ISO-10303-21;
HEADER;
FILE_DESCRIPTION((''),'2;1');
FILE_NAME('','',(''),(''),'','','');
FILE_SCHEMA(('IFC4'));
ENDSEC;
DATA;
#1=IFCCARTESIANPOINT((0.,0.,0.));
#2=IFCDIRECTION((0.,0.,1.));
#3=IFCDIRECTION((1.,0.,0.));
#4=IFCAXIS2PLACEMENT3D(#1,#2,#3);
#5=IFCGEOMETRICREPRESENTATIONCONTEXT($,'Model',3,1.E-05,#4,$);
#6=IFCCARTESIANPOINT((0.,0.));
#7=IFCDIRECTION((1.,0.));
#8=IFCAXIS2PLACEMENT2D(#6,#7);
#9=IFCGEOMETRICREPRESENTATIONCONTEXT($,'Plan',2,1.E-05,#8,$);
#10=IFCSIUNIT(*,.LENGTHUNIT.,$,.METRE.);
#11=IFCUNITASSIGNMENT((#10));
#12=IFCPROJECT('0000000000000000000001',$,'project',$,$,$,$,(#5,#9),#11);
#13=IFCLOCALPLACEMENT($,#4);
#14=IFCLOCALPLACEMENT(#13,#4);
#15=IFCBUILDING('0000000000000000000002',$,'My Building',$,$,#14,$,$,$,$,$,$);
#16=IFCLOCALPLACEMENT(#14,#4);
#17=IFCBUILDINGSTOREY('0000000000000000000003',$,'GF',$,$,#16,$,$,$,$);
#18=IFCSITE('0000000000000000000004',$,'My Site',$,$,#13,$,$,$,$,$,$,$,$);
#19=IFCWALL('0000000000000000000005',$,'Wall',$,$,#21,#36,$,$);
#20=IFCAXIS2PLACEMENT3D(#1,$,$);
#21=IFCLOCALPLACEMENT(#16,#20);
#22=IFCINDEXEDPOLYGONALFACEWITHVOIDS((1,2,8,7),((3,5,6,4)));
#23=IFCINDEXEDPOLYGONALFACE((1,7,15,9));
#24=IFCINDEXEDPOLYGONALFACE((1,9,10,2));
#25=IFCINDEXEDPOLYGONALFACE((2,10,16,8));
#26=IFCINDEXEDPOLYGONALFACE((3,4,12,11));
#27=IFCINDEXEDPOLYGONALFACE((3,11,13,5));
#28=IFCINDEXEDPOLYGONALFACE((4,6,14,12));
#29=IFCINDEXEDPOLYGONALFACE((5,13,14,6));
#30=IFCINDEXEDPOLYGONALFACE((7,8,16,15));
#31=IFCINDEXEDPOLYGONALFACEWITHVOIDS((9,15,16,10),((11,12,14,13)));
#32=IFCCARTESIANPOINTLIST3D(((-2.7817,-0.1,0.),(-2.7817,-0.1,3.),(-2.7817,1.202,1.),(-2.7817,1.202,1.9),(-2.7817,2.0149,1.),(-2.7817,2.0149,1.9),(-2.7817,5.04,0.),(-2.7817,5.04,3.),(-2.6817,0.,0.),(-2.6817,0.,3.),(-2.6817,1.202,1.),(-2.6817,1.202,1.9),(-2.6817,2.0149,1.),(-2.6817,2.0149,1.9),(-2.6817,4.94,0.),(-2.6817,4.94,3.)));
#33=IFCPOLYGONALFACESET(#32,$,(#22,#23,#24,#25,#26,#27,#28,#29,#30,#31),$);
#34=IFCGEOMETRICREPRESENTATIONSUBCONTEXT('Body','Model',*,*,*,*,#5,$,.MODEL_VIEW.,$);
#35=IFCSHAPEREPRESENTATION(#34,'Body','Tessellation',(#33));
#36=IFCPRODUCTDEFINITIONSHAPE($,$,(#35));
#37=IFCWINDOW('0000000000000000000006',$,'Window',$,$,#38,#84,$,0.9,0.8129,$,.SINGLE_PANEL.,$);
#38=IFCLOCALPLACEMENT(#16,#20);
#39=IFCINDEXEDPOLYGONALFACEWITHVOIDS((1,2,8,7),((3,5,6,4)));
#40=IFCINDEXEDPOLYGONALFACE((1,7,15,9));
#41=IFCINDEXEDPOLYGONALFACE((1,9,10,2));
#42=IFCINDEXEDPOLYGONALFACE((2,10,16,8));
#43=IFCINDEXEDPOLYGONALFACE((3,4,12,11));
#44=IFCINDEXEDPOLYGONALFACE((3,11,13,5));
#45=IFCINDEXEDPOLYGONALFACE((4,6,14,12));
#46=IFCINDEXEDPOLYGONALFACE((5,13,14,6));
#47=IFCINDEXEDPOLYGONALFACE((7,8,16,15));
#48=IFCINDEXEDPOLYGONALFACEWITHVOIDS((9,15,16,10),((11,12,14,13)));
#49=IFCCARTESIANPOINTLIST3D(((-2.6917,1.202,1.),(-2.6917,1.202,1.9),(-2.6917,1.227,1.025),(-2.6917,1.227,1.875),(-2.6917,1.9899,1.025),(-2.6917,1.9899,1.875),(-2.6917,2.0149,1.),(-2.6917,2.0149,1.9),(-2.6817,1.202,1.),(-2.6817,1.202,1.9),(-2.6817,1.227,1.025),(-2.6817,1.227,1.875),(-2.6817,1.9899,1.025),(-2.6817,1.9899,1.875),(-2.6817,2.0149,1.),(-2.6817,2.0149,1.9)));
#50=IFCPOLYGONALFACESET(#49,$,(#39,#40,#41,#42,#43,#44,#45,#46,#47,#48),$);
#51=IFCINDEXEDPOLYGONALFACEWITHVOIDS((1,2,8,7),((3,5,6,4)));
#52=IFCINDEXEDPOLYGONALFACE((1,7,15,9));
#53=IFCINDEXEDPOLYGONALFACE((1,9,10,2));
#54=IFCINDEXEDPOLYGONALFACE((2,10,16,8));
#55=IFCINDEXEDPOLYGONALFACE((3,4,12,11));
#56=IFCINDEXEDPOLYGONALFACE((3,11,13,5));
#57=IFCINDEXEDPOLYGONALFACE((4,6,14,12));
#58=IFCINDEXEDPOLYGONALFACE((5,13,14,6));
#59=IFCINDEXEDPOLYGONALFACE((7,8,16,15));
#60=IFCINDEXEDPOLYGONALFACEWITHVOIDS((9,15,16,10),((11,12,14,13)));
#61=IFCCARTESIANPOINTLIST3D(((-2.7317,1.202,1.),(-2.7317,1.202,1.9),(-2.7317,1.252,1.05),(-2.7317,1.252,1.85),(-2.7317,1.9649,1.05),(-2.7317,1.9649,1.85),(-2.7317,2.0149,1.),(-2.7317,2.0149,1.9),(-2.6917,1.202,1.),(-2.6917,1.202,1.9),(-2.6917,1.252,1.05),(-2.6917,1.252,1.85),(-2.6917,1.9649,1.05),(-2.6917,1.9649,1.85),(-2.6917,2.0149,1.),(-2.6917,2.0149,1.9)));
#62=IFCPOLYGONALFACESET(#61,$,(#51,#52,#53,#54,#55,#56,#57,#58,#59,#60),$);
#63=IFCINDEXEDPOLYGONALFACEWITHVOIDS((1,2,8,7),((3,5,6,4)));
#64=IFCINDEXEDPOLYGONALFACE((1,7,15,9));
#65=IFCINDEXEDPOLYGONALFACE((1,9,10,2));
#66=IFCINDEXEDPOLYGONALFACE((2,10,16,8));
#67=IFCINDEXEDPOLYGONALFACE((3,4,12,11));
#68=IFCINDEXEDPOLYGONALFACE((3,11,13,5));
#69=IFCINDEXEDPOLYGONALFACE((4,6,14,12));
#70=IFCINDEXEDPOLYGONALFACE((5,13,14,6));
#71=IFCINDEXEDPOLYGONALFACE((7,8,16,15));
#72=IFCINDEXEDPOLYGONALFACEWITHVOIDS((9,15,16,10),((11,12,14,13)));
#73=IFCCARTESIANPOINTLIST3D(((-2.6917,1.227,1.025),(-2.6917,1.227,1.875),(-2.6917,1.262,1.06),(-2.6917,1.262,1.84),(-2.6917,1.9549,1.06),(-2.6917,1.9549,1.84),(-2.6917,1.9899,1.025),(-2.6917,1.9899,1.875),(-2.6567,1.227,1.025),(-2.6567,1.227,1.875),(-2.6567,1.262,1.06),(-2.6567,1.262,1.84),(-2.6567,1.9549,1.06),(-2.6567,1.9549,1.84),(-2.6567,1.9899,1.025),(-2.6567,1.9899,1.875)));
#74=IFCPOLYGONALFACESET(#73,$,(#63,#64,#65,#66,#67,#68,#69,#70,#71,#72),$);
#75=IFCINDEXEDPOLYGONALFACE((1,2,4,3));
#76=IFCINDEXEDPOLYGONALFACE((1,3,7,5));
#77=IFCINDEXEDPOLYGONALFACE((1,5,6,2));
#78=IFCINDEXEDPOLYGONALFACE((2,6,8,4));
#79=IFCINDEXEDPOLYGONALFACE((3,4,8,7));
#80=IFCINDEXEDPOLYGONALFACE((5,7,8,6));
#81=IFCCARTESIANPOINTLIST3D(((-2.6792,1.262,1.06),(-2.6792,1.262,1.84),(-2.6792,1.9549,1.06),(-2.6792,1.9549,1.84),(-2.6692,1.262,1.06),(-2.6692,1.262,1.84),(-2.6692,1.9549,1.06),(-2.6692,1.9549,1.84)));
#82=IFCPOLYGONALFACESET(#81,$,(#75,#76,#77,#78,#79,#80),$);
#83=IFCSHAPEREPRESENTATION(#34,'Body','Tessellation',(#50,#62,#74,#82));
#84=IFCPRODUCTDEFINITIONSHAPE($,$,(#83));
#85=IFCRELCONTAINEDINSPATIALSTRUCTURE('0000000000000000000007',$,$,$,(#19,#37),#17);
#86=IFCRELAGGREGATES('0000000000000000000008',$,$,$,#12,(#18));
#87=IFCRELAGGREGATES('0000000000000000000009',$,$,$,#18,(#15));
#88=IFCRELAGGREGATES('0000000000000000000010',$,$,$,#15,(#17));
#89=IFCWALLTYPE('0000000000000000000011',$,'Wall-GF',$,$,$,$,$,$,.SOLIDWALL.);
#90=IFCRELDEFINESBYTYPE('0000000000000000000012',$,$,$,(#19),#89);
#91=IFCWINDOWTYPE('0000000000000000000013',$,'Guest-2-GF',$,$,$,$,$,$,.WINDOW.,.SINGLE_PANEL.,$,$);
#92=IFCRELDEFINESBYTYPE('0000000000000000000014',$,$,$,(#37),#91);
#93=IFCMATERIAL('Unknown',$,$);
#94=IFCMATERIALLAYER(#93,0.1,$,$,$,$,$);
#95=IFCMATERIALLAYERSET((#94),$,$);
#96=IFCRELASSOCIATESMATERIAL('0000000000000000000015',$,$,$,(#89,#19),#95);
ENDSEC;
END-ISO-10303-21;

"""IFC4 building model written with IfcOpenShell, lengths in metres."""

from ifc_helpers import new_model, entity, si_unit, frame, origin_with_axes, origin_2d_with_axis, place, context, subcontext, project, spatial, line, indexed_curve, outline, extrude, shape, source, transform, mapped, material, layer, layer_set, layer_usage, type_object, type_shapes, element, fill, save


model = new_model("IFC4")

# Units and contexts
model_context = context("Model", 3, precision=1e-05, world=origin_with_axes())
plan_context = context("Plan", 2, precision=1e-05, world=origin_2d_with_axis())
body_context_1 = subcontext(model_context, "Body", "Model", "MODEL_VIEW")
body_context_2 = subcontext(plan_context, "Body", "Plan", "PLAN_VIEW")
ifc_project = project(units=[si_unit("LENGTHUNIT", "METRE")], contexts=[model_context, plan_context])

# Site, building, storey
site_placement = place(None, origin_with_axes())
site = spatial("IfcSite", under=ifc_project, at=site_placement, Name="My Site")
building_placement = place(site_placement, origin_with_axes())
building = spatial("IfcBuilding", under=site, at=building_placement, Name="My Building")
storey_placement = place(building_placement, origin_with_axes())
storey = spatial("IfcBuildingStorey", under=building, at=storey_placement, Name="GF")

# Shared definitions
ifc_material_1 = material(Name="Unknown")

# Shared definitions
ifc_layer_1 = layer(ifc_material_1, 0.1)
ifc_layer_set_1 = layer_set([ifc_layer_1])
wall_type = type_object("IfcWallType", Name="Wall-GF", PredefinedType="SOLIDWALL", material=ifc_layer_set_1)

# Wall, opening, window
ifc_layer_usage_1 = layer_usage(ifc_layer_set_1, "AXIS2", "POSITIVE", 0.0)
wall_1_placement = place(storey_placement, frame((-2.7817, 5.04, 0.0), z_axis=(0.0, 0.0, 1.0), x_axis=(0.0, -1.0, 0.0)))
wall_1 = element("IfcWall", 1, at=wall_1_placement, inside=storey, type_object=wall_type, material=ifc_layer_usage_1, Name="Wall", context=body_context_1, shape_type="SweptSolid", body=[
    extrude(outline(indexed_curve([(0.0, 0.0), (0.1, 0.1), (5.04, 0.1), (5.14, 0.0)], segments=[line(1, 2, 3, 4, 1)])), origin_with_axes(), (0.0, 0.0, 1.0), 3.0),
])
shared_shape_1 = source(origin_with_axes(), body_context_1, "Body", "SweptSolid", [
    extrude(outline(indexed_curve([(0.0, 0.0), (0.8129, 0.0), (0.8129, 0.9), (0.0, 0.9)], segments=[line(1, 2, 3, 4, 1)])), frame((0.0, -0.6, 0.0), z_axis=(0.0, -1.0, 0.0), x_axis=(1.0, 0.0, 0.0)), (0.0, 0.0, -1.0), 1.2),
])
opening_1_placement = place(wall_1_placement, frame((3.0251, 0.0, 1.0), z_axis=(0.0, 0.0, 1.0), x_axis=(1.0, 0.0, 0.0)))
opening_1 = element("IfcOpeningElement", 2, at=opening_1_placement, cuts=wall_1, PredefinedType="OPENING", context=body_context_1, shape_type="MappedRepresentation", body=[
    mapped(shared_shape_1, transform((0.0, 0.0, 0.0), x_axis=(1.0, 0.0, 0.0), y_axis=(0.0, 1.0, 0.0), z_axis=(0.0, 0.0, 1.0), scale=1.0)),
])
window_type_1 = type_object("IfcWindowType", Name="Guest-2-GF", PartitioningType="SINGLE_PANEL", PredefinedType="WINDOW")
shared_shape_2 = source(origin_with_axes(), body_context_1, "Body", "SweptSolid", [
    extrude(outline(indexed_curve([(0.0, 0.0), (0.8129, 0.0), (0.8129, 0.9), (0.0, 0.9)], segments=[line(1, 2, 3, 4, 1)]), holes=[indexed_curve([(0.025, 0.025), (0.7879, 0.025), (0.7879, 0.875), (0.025, 0.875)], segments=[line(1, 2, 3, 4, 1)])]), frame((0.0, 0.09, 0.0), z_axis=(0.0, -1.0, 0.0), x_axis=(1.0, 0.0, 0.0)), (0.0, 0.0, -1.0), 0.01),
    extrude(outline(indexed_curve([(0.0, 0.0), (0.8129, 0.0), (0.8129, 0.9), (0.0, 0.9)], segments=[line(1, 2, 3, 4, 1)]), holes=[indexed_curve([(0.05, 0.05), (0.7629, 0.05), (0.7629, 0.85), (0.05, 0.85)], segments=[line(1, 2, 3, 4, 1)])]), frame((0.0, 0.05, 0.0), z_axis=(0.0, -1.0, 0.0), x_axis=(1.0, 0.0, 0.0)), (0.0, 0.0, -1.0), 0.04),
    extrude(outline(indexed_curve([(0.0, 0.0), (0.7629, 0.0), (0.7629, 0.85), (0.0, 0.85)], segments=[line(1, 2, 3, 4, 1)]), holes=[indexed_curve([(0.035, 0.035), (0.7279, 0.035), (0.7279, 0.815), (0.035, 0.815)], segments=[line(1, 2, 3, 4, 1)])]), frame((0.025, 0.09, 0.025), z_axis=(0.0, -1.0, 0.0), x_axis=(1.0, 0.0, 0.0)), (0.0, 0.0, -1.0), 0.035),
    extrude(outline(indexed_curve([(0.035, 0.035), (0.7279, 0.035), (0.7279, 0.815), (0.035, 0.815)], segments=[line(1, 2, 3, 4, 1)])), frame((0.025, 0.1025, 0.025), z_axis=(0.0, -1.0, 0.0), x_axis=(1.0, 0.0, 0.0)), (0.0, 0.0, -1.0), 0.01),
])
shared_shape_3 = source(origin_with_axes(), body_context_2, "Body", "Curve2D", [
    entity("IfcIndexedPolyCurve", entity("IfcCartesianPointList2D", [[0.05, 0.05], [0.7629, 0.05]])),
    entity("IfcIndexedPolyCurve", entity("IfcCartesianPointList2D", [[0.0, 0.1], [0.025, 0.1], [0.025, 0.09], [0.05, 0.09], [0.05, 0.05], [0.0, 0.05]]), [entity("IfcLineIndex", [1, 2, 3, 4, 5, 6, 1])]),
    entity("IfcIndexedPolyCurve", entity("IfcCartesianPointList2D", [[0.8129, 0.1], [0.7879, 0.1], [0.7879, 0.09], [0.7629, 0.09], [0.7629, 0.05], [0.8129, 0.05]]), [entity("IfcLineIndex", [1, 2, 3, 4, 5, 6, 1])]),
    entity("IfcIndexedPolyCurve", entity("IfcCartesianPointList2D", [[0.025, 0.09], [0.06, 0.09], [0.06, 0.125], [0.025, 0.125]]), [entity("IfcLineIndex", [1, 2, 3, 4, 1])]),
    entity("IfcIndexedPolyCurve", entity("IfcCartesianPointList2D", [[0.7879, 0.09], [0.7529, 0.09], [0.7529, 0.125], [0.7879, 0.125]]), [entity("IfcLineIndex", [1, 2, 3, 4, 1])]),
    entity("IfcIndexedPolyCurve", entity("IfcCartesianPointList2D", [[0.06, 0.09], [0.7529, 0.09]])),
    entity("IfcIndexedPolyCurve", entity("IfcCartesianPointList2D", [[0.06, 0.125], [0.7529, 0.125]])),
    entity("IfcIndexedPolyCurve", entity("IfcCartesianPointList2D", [[0.06, 0.1075], [0.7529, 0.1075]])),
])
type_shapes(window_type_1, [shared_shape_2, shared_shape_3])
window_1_placement = place(opening_1_placement, frame((0.0, 0.0, 0.0), z_axis=(0.0, 0.0, 1.0), x_axis=(1.0, 0.0, 0.0)))
window_1 = element("IfcWindow", 3, at=window_1_placement, inside=storey, type_object=window_type_1, Name="Window", OverallHeight=0.9, OverallWidth=0.8129, PartitioningType="SINGLE_PANEL", shapes=[
    shape(body_context_1, "Body", "MappedRepresentation", [mapped(shared_shape_2, transform((0.0, 0.0, 0.0), x_axis=(1.0, 0.0, 0.0), y_axis=(0.0, 1.0, 0.0), z_axis=(0.0, 0.0, 1.0), scale=1.0))]),
    shape(body_context_2, "Body", "MappedRepresentation", [mapped(shared_shape_3, transform((0.0, 0.0, 0.0), x_axis=(1.0, 0.0, 0.0), y_axis=(0.0, 1.0, 0.0), z_axis=(0.0, 0.0, 1.0), scale=1.0))]),
])
fill(opening_1, window_1)

save(model, "model.ifc")
